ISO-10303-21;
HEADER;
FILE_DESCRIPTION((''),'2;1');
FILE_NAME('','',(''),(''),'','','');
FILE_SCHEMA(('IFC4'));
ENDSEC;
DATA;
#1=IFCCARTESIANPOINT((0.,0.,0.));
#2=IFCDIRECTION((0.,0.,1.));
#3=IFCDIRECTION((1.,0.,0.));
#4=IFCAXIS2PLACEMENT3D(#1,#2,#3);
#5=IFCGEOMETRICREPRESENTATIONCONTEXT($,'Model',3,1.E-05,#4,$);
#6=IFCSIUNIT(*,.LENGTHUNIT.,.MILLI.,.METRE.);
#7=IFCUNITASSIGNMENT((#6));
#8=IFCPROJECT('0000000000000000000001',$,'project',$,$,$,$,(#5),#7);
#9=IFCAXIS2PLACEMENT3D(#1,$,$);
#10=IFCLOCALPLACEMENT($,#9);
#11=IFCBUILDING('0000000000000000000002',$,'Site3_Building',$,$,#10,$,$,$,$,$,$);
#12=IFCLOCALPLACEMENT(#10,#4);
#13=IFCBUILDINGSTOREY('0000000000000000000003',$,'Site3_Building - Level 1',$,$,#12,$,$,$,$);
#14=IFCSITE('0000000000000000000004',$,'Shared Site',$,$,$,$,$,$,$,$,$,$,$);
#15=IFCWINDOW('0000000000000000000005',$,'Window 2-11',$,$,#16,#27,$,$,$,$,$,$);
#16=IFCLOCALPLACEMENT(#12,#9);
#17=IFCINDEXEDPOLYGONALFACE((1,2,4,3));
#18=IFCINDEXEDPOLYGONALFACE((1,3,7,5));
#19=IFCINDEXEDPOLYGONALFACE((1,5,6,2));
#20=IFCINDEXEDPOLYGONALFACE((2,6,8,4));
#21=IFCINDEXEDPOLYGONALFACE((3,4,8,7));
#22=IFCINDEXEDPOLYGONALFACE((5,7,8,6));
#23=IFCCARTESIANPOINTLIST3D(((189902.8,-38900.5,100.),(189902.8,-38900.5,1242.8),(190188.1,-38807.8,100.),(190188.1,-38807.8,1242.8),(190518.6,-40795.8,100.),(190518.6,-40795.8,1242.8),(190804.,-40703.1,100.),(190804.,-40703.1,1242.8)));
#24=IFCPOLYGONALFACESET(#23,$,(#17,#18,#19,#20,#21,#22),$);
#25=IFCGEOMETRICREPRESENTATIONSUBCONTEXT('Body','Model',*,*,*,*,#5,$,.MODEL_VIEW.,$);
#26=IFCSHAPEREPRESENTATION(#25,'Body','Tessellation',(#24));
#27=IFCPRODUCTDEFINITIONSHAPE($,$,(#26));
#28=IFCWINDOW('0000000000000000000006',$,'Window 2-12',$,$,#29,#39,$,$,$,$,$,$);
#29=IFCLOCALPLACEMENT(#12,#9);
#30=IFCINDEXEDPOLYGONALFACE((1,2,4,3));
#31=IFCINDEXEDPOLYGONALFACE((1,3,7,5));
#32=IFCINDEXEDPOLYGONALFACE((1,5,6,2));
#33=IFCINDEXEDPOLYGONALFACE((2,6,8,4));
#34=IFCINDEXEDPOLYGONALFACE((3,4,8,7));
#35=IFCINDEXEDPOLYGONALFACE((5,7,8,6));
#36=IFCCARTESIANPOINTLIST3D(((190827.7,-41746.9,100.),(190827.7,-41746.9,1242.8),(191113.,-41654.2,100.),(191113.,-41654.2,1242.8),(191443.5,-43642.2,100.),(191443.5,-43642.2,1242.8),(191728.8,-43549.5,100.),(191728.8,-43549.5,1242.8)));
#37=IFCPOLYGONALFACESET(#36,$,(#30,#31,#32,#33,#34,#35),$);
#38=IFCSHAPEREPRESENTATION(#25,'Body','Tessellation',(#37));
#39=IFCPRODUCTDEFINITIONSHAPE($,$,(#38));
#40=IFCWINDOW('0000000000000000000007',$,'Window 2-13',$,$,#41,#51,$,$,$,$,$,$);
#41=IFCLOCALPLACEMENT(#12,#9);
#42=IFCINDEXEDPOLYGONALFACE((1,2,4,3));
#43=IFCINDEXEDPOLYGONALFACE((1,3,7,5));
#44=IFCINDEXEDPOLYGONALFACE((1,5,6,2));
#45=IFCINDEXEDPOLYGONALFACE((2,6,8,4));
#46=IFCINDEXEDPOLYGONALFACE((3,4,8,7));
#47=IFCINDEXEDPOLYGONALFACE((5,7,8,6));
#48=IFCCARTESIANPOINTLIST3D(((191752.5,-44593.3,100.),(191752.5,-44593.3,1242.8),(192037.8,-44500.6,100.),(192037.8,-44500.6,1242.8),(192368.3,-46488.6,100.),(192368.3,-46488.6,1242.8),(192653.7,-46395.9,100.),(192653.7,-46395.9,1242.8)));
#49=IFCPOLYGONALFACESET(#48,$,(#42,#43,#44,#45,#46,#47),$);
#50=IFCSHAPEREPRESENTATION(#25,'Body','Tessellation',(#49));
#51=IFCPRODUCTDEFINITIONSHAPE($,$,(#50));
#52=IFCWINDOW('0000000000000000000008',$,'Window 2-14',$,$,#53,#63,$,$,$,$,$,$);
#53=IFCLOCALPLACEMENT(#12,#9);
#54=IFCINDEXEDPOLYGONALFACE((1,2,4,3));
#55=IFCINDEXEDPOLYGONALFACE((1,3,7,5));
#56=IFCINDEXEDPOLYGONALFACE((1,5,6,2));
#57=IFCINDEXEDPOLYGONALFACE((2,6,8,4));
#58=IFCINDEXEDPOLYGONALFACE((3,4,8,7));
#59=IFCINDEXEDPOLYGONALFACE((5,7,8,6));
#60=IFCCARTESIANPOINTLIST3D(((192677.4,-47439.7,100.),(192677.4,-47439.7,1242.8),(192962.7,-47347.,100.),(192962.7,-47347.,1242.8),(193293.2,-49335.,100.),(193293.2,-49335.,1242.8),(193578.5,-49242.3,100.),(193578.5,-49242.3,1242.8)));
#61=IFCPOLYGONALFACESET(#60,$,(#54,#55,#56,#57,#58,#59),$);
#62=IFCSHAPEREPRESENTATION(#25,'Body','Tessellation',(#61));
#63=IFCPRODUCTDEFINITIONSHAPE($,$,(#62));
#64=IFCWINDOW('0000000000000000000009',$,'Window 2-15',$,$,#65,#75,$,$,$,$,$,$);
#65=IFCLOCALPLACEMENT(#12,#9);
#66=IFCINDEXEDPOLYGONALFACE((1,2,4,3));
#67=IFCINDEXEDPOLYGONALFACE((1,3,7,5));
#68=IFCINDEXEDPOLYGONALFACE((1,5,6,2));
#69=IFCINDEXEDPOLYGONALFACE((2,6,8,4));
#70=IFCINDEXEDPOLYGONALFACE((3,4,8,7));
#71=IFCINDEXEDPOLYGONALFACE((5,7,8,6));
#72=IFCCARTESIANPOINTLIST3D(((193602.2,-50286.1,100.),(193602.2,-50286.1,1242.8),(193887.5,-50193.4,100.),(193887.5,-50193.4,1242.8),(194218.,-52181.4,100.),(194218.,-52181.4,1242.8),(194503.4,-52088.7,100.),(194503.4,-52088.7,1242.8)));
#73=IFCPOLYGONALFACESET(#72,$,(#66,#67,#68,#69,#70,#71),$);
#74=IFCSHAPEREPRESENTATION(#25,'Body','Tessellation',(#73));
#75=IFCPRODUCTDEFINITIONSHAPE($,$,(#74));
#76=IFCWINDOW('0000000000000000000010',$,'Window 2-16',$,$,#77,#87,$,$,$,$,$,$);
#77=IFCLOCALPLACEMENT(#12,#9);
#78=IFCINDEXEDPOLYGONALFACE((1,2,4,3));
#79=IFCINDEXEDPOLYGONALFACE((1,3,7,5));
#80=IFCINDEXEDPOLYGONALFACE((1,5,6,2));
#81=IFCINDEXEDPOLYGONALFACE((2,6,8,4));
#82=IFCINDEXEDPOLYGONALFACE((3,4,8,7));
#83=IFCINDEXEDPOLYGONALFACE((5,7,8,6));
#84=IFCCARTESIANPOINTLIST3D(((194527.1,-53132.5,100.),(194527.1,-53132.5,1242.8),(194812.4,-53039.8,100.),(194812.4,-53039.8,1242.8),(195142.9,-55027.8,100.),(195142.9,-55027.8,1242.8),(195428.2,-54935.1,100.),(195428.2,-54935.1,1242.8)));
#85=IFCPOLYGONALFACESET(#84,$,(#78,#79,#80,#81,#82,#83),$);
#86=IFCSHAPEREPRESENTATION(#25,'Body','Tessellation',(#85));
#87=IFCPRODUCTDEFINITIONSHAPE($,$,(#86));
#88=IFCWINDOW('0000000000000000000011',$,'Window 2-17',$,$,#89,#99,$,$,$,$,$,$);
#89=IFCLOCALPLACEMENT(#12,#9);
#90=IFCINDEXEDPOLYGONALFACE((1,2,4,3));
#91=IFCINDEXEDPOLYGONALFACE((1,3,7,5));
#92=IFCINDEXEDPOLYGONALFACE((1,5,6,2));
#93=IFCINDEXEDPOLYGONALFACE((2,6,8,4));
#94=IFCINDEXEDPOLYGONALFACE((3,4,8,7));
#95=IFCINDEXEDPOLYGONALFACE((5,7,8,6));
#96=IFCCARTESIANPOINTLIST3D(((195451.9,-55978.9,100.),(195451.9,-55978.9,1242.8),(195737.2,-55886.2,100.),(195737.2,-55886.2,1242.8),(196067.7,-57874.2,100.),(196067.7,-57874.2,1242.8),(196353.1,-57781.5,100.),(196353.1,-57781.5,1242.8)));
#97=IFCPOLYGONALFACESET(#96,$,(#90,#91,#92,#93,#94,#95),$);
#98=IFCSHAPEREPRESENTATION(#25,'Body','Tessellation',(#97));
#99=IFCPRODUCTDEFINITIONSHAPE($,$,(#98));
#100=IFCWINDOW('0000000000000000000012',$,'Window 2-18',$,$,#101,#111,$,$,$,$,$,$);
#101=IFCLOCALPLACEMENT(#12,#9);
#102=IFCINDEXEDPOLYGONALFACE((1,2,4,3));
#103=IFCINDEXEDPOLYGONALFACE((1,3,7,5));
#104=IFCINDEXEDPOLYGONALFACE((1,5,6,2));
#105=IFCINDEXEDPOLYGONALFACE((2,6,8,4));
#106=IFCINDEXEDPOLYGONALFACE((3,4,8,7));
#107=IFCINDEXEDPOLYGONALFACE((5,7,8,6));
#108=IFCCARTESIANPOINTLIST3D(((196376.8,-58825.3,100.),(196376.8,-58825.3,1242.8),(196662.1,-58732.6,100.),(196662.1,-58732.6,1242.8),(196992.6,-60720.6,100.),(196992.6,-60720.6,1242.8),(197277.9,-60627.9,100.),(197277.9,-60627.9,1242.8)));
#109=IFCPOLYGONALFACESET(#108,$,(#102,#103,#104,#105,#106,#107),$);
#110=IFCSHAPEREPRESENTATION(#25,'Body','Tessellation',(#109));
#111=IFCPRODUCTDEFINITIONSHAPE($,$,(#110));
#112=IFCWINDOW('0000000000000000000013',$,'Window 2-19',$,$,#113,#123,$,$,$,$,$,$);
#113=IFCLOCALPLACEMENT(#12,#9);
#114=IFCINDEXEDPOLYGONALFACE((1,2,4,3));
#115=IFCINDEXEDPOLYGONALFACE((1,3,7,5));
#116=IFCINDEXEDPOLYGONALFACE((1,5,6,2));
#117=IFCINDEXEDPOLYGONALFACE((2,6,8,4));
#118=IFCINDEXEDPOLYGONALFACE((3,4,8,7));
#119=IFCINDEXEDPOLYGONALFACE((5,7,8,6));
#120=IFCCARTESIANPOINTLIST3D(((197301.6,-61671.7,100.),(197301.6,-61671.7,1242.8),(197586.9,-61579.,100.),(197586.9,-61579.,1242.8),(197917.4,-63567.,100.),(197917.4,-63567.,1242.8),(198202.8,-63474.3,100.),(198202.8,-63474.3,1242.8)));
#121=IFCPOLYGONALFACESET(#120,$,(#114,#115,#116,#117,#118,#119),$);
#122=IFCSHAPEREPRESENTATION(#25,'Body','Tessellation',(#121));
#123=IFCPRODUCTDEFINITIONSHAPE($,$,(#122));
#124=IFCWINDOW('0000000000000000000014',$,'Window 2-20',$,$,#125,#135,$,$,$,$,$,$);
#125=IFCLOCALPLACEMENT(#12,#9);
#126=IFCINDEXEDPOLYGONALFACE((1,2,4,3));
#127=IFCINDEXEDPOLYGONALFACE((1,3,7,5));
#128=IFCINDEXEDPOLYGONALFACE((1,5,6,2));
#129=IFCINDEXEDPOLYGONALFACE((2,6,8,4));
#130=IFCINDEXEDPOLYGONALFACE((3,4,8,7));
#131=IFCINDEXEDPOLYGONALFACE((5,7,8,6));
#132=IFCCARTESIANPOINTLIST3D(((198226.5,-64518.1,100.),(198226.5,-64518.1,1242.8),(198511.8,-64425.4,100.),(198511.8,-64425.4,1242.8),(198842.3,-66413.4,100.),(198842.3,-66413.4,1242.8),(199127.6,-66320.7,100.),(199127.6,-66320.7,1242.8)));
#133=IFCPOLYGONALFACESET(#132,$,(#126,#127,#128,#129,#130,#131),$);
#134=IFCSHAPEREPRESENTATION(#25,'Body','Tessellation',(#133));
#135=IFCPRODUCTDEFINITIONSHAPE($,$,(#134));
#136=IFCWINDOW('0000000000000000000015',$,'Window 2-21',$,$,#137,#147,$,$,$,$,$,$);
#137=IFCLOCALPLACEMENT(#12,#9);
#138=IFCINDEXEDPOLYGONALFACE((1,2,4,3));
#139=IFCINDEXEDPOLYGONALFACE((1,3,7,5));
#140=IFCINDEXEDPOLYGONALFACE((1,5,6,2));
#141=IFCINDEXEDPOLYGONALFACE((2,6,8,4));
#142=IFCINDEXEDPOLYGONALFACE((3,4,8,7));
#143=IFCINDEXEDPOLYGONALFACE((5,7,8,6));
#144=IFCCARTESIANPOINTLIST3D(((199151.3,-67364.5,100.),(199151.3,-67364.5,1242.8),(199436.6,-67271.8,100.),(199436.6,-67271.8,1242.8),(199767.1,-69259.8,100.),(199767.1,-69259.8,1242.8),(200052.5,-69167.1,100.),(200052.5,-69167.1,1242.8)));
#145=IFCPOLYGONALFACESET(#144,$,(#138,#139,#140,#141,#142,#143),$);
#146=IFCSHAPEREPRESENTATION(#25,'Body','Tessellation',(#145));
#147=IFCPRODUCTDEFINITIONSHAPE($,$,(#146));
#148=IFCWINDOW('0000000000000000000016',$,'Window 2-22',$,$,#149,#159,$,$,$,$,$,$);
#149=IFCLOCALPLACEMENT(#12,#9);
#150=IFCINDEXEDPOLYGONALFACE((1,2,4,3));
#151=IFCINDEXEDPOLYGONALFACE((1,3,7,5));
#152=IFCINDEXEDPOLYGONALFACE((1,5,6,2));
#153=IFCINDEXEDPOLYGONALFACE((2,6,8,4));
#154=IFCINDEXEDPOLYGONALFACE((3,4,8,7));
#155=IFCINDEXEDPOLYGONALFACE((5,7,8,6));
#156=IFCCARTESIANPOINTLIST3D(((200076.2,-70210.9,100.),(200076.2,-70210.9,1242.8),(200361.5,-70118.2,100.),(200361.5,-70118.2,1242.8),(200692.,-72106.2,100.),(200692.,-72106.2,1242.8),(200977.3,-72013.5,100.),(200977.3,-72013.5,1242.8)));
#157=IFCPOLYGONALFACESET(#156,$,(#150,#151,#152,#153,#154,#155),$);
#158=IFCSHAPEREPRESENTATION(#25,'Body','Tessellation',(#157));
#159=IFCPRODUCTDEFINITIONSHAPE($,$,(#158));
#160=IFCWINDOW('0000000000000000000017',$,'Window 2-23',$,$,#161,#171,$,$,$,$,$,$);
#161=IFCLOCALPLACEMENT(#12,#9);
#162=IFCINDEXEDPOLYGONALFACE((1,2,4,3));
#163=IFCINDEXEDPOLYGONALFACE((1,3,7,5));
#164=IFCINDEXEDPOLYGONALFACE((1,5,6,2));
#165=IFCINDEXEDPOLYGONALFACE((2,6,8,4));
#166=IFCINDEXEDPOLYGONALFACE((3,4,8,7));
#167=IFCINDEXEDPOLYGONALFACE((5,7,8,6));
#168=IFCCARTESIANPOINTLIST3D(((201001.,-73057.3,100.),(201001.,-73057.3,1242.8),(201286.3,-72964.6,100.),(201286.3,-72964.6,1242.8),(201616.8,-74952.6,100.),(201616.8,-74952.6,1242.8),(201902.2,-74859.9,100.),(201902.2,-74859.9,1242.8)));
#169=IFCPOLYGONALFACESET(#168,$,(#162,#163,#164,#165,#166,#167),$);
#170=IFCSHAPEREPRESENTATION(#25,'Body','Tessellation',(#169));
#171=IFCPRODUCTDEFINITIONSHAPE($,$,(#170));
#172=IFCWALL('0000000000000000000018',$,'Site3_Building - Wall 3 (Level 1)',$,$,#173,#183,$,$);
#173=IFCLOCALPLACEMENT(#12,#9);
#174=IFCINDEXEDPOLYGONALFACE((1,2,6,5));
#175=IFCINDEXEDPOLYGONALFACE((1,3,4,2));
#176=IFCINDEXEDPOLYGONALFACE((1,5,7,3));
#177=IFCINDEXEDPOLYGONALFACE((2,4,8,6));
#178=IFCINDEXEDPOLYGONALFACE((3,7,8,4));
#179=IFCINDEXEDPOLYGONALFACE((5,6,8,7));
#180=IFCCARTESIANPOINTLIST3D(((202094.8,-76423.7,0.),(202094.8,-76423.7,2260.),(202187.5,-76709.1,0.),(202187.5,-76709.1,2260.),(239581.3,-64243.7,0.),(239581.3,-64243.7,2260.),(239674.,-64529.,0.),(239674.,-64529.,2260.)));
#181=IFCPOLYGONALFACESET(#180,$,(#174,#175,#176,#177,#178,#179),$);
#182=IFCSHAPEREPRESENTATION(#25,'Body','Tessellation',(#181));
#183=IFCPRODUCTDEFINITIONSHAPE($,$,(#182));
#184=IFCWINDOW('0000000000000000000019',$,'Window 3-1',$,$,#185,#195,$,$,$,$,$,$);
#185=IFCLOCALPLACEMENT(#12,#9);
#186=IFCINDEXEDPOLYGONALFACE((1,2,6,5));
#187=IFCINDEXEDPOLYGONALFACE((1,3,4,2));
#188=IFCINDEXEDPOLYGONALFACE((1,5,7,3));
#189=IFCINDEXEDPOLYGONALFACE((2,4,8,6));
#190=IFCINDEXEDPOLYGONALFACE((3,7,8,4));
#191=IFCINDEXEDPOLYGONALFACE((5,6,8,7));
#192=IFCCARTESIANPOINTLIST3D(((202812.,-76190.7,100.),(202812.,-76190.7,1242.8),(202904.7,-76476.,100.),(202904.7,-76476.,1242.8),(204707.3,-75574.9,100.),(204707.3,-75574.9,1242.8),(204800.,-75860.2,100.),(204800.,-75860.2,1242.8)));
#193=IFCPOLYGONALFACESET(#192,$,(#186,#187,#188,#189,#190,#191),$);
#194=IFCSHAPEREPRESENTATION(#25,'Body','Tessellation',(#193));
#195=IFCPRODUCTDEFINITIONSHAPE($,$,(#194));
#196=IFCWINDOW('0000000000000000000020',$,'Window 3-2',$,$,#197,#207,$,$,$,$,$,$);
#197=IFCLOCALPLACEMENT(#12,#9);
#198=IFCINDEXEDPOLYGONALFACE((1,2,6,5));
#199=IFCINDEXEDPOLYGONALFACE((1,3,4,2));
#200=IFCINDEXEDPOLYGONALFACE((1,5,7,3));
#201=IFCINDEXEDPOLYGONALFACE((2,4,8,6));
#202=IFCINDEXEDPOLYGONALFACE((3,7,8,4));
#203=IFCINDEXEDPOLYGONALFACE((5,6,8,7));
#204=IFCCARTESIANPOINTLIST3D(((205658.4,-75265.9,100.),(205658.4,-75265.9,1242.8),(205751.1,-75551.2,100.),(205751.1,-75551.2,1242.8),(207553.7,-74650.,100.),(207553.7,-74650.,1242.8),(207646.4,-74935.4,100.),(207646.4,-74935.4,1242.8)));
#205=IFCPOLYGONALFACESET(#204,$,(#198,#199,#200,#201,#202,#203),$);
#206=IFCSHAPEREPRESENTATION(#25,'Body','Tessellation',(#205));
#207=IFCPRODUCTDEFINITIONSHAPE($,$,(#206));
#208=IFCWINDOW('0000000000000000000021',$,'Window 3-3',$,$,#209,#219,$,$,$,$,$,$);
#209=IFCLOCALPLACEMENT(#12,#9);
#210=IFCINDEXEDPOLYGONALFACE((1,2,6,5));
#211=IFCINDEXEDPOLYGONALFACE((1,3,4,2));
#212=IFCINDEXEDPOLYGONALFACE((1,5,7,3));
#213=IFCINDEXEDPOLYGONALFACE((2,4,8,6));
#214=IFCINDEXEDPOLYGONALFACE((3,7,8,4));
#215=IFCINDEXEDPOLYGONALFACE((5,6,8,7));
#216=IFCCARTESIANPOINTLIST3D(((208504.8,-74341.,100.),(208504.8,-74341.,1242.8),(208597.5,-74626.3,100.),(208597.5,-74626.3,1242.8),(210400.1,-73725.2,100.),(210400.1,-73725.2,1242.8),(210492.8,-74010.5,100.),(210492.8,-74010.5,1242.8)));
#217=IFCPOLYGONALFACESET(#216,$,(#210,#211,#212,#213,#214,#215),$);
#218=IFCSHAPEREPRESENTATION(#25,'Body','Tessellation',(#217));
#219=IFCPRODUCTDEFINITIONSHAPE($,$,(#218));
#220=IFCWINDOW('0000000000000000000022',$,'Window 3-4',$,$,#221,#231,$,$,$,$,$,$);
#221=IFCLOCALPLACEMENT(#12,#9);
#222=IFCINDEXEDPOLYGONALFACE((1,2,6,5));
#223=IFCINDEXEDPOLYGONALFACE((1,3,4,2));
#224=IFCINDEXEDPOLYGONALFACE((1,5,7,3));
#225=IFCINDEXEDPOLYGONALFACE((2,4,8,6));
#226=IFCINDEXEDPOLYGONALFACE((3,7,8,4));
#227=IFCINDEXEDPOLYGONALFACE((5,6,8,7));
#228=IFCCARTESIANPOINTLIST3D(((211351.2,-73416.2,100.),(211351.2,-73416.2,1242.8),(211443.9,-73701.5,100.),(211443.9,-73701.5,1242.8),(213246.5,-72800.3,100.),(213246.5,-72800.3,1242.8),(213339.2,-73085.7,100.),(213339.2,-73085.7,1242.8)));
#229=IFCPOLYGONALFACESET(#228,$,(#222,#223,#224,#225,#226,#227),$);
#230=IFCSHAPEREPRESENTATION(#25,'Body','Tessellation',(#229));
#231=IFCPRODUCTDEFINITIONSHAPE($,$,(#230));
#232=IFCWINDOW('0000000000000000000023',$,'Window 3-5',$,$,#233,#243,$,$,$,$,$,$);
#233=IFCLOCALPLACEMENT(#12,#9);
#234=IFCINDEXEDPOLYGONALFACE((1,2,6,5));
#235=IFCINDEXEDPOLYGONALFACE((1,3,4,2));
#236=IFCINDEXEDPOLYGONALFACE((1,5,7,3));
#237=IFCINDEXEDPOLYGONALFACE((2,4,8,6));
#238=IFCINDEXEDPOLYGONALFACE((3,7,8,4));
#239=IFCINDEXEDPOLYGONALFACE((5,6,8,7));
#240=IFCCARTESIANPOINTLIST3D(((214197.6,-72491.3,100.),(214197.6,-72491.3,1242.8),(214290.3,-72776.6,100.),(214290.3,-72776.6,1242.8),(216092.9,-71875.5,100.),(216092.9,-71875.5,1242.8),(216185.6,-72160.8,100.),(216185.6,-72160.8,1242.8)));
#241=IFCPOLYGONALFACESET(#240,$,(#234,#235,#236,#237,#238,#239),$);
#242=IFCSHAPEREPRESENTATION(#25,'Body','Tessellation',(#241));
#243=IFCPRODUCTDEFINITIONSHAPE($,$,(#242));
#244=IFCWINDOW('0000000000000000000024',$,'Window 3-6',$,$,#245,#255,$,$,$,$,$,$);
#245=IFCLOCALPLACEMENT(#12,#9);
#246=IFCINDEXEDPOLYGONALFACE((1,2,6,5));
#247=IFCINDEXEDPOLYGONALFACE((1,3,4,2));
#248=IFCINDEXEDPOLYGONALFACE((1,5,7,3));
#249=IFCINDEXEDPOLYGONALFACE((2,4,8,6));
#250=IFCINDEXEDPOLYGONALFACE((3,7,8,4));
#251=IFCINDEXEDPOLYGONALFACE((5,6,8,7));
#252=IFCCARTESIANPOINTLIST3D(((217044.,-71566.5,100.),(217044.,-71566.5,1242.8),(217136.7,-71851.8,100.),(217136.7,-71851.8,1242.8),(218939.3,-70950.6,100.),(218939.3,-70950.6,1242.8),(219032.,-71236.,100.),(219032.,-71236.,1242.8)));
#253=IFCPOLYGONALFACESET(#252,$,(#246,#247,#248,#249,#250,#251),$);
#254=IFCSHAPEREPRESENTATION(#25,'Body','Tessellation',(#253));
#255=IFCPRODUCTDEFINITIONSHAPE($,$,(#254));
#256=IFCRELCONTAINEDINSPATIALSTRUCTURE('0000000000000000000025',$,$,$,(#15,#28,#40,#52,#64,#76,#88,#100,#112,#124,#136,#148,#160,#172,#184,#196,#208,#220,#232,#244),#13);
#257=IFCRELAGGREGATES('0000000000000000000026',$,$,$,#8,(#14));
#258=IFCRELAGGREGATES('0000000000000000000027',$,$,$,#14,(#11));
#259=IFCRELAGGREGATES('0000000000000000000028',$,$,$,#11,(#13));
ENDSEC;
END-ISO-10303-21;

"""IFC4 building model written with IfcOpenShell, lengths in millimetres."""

from ifc_helpers import new_model, si_unit, frame, origin, origin_with_axes, place, context, subcontext, project, spatial, indexed_curve, outline, extrude, element, save


model = new_model("IFC4")

# Units and contexts
model_context = context("Model", 3, precision=1e-05, world=origin_with_axes())
body_context = subcontext(model_context, "Body", "Model", "MODEL_VIEW")
ifc_project = project(units=[si_unit("LENGTHUNIT", "METRE", prefix="MILLI")], contexts=[model_context])

# Site, building, storey
site = spatial("IfcSite", under=ifc_project, Name="Shared Site")
building_placement = place(None, origin())
building = spatial("IfcBuilding", under=site, at=building_placement, Name="Site3_Building")
storey_placement = place(building_placement, origin_with_axes())
storey = spatial("IfcBuildingStorey", under=building, at=storey_placement, Name="Site3_Building - Level 1")

# Windows
for number, where, z_axis, x_axis, name in (
    (1, (189902.8, -38900.5, 100.0), (0.0, 0.0, 1.0), (0.309017, -0.951057, 0.0), "Window 2-11"),
    (2, (190827.7, -41746.9, 100.0), (0.0, 0.0, 1.0), (0.309017, -0.951057, 0.0), "Window 2-12"),
    (3, (191752.5, -44593.3, 100.0), (0.0, 0.0, 1.0), (0.309017, -0.951057, 0.0), "Window 2-13"),
    (4, (192677.4, -47439.7, 100.0), (0.0, 0.0, 1.0), (0.309017, -0.951057, 0.0), "Window 2-14"),
    (5, (193602.2, -50286.1, 100.0), (0.0, 0.0, 1.0), (0.309017, -0.951057, 0.0), "Window 2-15"),
    (6, (194527.1, -53132.5, 100.0), (0.0, 0.0, 1.0), (0.309017, -0.951057, 0.0), "Window 2-16"),
    (7, (195451.9, -55978.9, 100.0), (0.0, 0.0, 1.0), (0.309017, -0.951057, 0.0), "Window 2-17"),
    (8, (196376.8, -58825.3, 100.0), (0.0, 0.0, 1.0), (0.309017, -0.951057, 0.0), "Window 2-18"),
    (9, (197301.6, -61671.7, 100.0), (0.0, 0.0, 1.0), (0.309017, -0.951057, 0.0), "Window 2-19"),
    (10, (198226.5, -64518.1, 100.0), (0.0, 0.0, 1.0), (0.309017, -0.951057, 0.0), "Window 2-20"),
    (11, (199151.3, -67364.5, 100.0), (0.0, 0.0, 1.0), (0.309017, -0.951057, 0.0), "Window 2-21"),
    (12, (200076.2, -70210.9, 100.0), (0.0, 0.0, 1.0), (0.309017, -0.951057, 0.0), "Window 2-22"),
    (13, (201001.0, -73057.3, 100.0), (0.0, 0.0, 1.0), (0.309017, -0.951057, 0.0), "Window 2-23"),
):
    element("IfcWindow", number, at=place(storey_placement, frame(where, z_axis=z_axis, x_axis=x_axis)), inside=storey, Name=name, context=body_context, shape_type="SweptSolid", body=[
        extrude(outline(indexed_curve([(0.0, 0.0), (0.0, 300.0), (1992.9, 300.0), (1992.9, 0.0), (0.0, 0.0)], self_intersect=False)), origin_with_axes(), (0.0, 0.0, 1.0), 1142.8),
    ])

# Wall
wall_1_placement = place(storey_placement, frame((202187.5, -76709.1, 0.0), z_axis=(0.0, 0.0, 1.0), x_axis=(0.951057, 0.309017, 0.0)))
element("IfcWall", 14, at=wall_1_placement, inside=storey, Name="Site3_Building - Wall 3 (Level 1)", context=body_context, shape_type="SweptSolid", body=[
    extrude(outline(indexed_curve([(0.0, 0.0), (0.0, 300.0), (39415.5, 300.0), (39415.5, 0.0), (0.0, 0.0)], self_intersect=False)), origin_with_axes(), (0.0, 0.0, 1.0), 2260.0),
])

# Windows
for number, where, z_axis, x_axis, name in (
    (15, (202904.7, -76476.0, 100.0), (0.0, 0.0, 1.0), (0.951057, 0.309017, 0.0), "Window 3-1"),
    (16, (205751.1, -75551.2, 100.0), (0.0, 0.0, 1.0), (0.951057, 0.309017, 0.0), "Window 3-2"),
    (17, (208597.5, -74626.3, 100.0), (0.0, 0.0, 1.0), (0.951057, 0.309017, 0.0), "Window 3-3"),
    (18, (211443.9, -73701.5, 100.0), (0.0, 0.0, 1.0), (0.951057, 0.309017, 0.0), "Window 3-4"),
    (19, (214290.3, -72776.6, 100.0), (0.0, 0.0, 1.0), (0.951057, 0.309017, 0.0), "Window 3-5"),
    (20, (217136.7, -71851.8, 100.0), (0.0, 0.0, 1.0), (0.951057, 0.309017, 0.0), "Window 3-6"),
):
    element("IfcWindow", number, at=place(storey_placement, frame(where, z_axis=z_axis, x_axis=x_axis)), inside=storey, Name=name, context=body_context, shape_type="SweptSolid", body=[
        extrude(outline(indexed_curve([(0.0, 0.0), (0.0, 300.0), (1992.9, 300.0), (1992.9, 0.0), (0.0, 0.0)], self_intersect=False)), origin_with_axes(), (0.0, 0.0, 1.0), 1142.8),
    ])

save(model, "model.ifc")
